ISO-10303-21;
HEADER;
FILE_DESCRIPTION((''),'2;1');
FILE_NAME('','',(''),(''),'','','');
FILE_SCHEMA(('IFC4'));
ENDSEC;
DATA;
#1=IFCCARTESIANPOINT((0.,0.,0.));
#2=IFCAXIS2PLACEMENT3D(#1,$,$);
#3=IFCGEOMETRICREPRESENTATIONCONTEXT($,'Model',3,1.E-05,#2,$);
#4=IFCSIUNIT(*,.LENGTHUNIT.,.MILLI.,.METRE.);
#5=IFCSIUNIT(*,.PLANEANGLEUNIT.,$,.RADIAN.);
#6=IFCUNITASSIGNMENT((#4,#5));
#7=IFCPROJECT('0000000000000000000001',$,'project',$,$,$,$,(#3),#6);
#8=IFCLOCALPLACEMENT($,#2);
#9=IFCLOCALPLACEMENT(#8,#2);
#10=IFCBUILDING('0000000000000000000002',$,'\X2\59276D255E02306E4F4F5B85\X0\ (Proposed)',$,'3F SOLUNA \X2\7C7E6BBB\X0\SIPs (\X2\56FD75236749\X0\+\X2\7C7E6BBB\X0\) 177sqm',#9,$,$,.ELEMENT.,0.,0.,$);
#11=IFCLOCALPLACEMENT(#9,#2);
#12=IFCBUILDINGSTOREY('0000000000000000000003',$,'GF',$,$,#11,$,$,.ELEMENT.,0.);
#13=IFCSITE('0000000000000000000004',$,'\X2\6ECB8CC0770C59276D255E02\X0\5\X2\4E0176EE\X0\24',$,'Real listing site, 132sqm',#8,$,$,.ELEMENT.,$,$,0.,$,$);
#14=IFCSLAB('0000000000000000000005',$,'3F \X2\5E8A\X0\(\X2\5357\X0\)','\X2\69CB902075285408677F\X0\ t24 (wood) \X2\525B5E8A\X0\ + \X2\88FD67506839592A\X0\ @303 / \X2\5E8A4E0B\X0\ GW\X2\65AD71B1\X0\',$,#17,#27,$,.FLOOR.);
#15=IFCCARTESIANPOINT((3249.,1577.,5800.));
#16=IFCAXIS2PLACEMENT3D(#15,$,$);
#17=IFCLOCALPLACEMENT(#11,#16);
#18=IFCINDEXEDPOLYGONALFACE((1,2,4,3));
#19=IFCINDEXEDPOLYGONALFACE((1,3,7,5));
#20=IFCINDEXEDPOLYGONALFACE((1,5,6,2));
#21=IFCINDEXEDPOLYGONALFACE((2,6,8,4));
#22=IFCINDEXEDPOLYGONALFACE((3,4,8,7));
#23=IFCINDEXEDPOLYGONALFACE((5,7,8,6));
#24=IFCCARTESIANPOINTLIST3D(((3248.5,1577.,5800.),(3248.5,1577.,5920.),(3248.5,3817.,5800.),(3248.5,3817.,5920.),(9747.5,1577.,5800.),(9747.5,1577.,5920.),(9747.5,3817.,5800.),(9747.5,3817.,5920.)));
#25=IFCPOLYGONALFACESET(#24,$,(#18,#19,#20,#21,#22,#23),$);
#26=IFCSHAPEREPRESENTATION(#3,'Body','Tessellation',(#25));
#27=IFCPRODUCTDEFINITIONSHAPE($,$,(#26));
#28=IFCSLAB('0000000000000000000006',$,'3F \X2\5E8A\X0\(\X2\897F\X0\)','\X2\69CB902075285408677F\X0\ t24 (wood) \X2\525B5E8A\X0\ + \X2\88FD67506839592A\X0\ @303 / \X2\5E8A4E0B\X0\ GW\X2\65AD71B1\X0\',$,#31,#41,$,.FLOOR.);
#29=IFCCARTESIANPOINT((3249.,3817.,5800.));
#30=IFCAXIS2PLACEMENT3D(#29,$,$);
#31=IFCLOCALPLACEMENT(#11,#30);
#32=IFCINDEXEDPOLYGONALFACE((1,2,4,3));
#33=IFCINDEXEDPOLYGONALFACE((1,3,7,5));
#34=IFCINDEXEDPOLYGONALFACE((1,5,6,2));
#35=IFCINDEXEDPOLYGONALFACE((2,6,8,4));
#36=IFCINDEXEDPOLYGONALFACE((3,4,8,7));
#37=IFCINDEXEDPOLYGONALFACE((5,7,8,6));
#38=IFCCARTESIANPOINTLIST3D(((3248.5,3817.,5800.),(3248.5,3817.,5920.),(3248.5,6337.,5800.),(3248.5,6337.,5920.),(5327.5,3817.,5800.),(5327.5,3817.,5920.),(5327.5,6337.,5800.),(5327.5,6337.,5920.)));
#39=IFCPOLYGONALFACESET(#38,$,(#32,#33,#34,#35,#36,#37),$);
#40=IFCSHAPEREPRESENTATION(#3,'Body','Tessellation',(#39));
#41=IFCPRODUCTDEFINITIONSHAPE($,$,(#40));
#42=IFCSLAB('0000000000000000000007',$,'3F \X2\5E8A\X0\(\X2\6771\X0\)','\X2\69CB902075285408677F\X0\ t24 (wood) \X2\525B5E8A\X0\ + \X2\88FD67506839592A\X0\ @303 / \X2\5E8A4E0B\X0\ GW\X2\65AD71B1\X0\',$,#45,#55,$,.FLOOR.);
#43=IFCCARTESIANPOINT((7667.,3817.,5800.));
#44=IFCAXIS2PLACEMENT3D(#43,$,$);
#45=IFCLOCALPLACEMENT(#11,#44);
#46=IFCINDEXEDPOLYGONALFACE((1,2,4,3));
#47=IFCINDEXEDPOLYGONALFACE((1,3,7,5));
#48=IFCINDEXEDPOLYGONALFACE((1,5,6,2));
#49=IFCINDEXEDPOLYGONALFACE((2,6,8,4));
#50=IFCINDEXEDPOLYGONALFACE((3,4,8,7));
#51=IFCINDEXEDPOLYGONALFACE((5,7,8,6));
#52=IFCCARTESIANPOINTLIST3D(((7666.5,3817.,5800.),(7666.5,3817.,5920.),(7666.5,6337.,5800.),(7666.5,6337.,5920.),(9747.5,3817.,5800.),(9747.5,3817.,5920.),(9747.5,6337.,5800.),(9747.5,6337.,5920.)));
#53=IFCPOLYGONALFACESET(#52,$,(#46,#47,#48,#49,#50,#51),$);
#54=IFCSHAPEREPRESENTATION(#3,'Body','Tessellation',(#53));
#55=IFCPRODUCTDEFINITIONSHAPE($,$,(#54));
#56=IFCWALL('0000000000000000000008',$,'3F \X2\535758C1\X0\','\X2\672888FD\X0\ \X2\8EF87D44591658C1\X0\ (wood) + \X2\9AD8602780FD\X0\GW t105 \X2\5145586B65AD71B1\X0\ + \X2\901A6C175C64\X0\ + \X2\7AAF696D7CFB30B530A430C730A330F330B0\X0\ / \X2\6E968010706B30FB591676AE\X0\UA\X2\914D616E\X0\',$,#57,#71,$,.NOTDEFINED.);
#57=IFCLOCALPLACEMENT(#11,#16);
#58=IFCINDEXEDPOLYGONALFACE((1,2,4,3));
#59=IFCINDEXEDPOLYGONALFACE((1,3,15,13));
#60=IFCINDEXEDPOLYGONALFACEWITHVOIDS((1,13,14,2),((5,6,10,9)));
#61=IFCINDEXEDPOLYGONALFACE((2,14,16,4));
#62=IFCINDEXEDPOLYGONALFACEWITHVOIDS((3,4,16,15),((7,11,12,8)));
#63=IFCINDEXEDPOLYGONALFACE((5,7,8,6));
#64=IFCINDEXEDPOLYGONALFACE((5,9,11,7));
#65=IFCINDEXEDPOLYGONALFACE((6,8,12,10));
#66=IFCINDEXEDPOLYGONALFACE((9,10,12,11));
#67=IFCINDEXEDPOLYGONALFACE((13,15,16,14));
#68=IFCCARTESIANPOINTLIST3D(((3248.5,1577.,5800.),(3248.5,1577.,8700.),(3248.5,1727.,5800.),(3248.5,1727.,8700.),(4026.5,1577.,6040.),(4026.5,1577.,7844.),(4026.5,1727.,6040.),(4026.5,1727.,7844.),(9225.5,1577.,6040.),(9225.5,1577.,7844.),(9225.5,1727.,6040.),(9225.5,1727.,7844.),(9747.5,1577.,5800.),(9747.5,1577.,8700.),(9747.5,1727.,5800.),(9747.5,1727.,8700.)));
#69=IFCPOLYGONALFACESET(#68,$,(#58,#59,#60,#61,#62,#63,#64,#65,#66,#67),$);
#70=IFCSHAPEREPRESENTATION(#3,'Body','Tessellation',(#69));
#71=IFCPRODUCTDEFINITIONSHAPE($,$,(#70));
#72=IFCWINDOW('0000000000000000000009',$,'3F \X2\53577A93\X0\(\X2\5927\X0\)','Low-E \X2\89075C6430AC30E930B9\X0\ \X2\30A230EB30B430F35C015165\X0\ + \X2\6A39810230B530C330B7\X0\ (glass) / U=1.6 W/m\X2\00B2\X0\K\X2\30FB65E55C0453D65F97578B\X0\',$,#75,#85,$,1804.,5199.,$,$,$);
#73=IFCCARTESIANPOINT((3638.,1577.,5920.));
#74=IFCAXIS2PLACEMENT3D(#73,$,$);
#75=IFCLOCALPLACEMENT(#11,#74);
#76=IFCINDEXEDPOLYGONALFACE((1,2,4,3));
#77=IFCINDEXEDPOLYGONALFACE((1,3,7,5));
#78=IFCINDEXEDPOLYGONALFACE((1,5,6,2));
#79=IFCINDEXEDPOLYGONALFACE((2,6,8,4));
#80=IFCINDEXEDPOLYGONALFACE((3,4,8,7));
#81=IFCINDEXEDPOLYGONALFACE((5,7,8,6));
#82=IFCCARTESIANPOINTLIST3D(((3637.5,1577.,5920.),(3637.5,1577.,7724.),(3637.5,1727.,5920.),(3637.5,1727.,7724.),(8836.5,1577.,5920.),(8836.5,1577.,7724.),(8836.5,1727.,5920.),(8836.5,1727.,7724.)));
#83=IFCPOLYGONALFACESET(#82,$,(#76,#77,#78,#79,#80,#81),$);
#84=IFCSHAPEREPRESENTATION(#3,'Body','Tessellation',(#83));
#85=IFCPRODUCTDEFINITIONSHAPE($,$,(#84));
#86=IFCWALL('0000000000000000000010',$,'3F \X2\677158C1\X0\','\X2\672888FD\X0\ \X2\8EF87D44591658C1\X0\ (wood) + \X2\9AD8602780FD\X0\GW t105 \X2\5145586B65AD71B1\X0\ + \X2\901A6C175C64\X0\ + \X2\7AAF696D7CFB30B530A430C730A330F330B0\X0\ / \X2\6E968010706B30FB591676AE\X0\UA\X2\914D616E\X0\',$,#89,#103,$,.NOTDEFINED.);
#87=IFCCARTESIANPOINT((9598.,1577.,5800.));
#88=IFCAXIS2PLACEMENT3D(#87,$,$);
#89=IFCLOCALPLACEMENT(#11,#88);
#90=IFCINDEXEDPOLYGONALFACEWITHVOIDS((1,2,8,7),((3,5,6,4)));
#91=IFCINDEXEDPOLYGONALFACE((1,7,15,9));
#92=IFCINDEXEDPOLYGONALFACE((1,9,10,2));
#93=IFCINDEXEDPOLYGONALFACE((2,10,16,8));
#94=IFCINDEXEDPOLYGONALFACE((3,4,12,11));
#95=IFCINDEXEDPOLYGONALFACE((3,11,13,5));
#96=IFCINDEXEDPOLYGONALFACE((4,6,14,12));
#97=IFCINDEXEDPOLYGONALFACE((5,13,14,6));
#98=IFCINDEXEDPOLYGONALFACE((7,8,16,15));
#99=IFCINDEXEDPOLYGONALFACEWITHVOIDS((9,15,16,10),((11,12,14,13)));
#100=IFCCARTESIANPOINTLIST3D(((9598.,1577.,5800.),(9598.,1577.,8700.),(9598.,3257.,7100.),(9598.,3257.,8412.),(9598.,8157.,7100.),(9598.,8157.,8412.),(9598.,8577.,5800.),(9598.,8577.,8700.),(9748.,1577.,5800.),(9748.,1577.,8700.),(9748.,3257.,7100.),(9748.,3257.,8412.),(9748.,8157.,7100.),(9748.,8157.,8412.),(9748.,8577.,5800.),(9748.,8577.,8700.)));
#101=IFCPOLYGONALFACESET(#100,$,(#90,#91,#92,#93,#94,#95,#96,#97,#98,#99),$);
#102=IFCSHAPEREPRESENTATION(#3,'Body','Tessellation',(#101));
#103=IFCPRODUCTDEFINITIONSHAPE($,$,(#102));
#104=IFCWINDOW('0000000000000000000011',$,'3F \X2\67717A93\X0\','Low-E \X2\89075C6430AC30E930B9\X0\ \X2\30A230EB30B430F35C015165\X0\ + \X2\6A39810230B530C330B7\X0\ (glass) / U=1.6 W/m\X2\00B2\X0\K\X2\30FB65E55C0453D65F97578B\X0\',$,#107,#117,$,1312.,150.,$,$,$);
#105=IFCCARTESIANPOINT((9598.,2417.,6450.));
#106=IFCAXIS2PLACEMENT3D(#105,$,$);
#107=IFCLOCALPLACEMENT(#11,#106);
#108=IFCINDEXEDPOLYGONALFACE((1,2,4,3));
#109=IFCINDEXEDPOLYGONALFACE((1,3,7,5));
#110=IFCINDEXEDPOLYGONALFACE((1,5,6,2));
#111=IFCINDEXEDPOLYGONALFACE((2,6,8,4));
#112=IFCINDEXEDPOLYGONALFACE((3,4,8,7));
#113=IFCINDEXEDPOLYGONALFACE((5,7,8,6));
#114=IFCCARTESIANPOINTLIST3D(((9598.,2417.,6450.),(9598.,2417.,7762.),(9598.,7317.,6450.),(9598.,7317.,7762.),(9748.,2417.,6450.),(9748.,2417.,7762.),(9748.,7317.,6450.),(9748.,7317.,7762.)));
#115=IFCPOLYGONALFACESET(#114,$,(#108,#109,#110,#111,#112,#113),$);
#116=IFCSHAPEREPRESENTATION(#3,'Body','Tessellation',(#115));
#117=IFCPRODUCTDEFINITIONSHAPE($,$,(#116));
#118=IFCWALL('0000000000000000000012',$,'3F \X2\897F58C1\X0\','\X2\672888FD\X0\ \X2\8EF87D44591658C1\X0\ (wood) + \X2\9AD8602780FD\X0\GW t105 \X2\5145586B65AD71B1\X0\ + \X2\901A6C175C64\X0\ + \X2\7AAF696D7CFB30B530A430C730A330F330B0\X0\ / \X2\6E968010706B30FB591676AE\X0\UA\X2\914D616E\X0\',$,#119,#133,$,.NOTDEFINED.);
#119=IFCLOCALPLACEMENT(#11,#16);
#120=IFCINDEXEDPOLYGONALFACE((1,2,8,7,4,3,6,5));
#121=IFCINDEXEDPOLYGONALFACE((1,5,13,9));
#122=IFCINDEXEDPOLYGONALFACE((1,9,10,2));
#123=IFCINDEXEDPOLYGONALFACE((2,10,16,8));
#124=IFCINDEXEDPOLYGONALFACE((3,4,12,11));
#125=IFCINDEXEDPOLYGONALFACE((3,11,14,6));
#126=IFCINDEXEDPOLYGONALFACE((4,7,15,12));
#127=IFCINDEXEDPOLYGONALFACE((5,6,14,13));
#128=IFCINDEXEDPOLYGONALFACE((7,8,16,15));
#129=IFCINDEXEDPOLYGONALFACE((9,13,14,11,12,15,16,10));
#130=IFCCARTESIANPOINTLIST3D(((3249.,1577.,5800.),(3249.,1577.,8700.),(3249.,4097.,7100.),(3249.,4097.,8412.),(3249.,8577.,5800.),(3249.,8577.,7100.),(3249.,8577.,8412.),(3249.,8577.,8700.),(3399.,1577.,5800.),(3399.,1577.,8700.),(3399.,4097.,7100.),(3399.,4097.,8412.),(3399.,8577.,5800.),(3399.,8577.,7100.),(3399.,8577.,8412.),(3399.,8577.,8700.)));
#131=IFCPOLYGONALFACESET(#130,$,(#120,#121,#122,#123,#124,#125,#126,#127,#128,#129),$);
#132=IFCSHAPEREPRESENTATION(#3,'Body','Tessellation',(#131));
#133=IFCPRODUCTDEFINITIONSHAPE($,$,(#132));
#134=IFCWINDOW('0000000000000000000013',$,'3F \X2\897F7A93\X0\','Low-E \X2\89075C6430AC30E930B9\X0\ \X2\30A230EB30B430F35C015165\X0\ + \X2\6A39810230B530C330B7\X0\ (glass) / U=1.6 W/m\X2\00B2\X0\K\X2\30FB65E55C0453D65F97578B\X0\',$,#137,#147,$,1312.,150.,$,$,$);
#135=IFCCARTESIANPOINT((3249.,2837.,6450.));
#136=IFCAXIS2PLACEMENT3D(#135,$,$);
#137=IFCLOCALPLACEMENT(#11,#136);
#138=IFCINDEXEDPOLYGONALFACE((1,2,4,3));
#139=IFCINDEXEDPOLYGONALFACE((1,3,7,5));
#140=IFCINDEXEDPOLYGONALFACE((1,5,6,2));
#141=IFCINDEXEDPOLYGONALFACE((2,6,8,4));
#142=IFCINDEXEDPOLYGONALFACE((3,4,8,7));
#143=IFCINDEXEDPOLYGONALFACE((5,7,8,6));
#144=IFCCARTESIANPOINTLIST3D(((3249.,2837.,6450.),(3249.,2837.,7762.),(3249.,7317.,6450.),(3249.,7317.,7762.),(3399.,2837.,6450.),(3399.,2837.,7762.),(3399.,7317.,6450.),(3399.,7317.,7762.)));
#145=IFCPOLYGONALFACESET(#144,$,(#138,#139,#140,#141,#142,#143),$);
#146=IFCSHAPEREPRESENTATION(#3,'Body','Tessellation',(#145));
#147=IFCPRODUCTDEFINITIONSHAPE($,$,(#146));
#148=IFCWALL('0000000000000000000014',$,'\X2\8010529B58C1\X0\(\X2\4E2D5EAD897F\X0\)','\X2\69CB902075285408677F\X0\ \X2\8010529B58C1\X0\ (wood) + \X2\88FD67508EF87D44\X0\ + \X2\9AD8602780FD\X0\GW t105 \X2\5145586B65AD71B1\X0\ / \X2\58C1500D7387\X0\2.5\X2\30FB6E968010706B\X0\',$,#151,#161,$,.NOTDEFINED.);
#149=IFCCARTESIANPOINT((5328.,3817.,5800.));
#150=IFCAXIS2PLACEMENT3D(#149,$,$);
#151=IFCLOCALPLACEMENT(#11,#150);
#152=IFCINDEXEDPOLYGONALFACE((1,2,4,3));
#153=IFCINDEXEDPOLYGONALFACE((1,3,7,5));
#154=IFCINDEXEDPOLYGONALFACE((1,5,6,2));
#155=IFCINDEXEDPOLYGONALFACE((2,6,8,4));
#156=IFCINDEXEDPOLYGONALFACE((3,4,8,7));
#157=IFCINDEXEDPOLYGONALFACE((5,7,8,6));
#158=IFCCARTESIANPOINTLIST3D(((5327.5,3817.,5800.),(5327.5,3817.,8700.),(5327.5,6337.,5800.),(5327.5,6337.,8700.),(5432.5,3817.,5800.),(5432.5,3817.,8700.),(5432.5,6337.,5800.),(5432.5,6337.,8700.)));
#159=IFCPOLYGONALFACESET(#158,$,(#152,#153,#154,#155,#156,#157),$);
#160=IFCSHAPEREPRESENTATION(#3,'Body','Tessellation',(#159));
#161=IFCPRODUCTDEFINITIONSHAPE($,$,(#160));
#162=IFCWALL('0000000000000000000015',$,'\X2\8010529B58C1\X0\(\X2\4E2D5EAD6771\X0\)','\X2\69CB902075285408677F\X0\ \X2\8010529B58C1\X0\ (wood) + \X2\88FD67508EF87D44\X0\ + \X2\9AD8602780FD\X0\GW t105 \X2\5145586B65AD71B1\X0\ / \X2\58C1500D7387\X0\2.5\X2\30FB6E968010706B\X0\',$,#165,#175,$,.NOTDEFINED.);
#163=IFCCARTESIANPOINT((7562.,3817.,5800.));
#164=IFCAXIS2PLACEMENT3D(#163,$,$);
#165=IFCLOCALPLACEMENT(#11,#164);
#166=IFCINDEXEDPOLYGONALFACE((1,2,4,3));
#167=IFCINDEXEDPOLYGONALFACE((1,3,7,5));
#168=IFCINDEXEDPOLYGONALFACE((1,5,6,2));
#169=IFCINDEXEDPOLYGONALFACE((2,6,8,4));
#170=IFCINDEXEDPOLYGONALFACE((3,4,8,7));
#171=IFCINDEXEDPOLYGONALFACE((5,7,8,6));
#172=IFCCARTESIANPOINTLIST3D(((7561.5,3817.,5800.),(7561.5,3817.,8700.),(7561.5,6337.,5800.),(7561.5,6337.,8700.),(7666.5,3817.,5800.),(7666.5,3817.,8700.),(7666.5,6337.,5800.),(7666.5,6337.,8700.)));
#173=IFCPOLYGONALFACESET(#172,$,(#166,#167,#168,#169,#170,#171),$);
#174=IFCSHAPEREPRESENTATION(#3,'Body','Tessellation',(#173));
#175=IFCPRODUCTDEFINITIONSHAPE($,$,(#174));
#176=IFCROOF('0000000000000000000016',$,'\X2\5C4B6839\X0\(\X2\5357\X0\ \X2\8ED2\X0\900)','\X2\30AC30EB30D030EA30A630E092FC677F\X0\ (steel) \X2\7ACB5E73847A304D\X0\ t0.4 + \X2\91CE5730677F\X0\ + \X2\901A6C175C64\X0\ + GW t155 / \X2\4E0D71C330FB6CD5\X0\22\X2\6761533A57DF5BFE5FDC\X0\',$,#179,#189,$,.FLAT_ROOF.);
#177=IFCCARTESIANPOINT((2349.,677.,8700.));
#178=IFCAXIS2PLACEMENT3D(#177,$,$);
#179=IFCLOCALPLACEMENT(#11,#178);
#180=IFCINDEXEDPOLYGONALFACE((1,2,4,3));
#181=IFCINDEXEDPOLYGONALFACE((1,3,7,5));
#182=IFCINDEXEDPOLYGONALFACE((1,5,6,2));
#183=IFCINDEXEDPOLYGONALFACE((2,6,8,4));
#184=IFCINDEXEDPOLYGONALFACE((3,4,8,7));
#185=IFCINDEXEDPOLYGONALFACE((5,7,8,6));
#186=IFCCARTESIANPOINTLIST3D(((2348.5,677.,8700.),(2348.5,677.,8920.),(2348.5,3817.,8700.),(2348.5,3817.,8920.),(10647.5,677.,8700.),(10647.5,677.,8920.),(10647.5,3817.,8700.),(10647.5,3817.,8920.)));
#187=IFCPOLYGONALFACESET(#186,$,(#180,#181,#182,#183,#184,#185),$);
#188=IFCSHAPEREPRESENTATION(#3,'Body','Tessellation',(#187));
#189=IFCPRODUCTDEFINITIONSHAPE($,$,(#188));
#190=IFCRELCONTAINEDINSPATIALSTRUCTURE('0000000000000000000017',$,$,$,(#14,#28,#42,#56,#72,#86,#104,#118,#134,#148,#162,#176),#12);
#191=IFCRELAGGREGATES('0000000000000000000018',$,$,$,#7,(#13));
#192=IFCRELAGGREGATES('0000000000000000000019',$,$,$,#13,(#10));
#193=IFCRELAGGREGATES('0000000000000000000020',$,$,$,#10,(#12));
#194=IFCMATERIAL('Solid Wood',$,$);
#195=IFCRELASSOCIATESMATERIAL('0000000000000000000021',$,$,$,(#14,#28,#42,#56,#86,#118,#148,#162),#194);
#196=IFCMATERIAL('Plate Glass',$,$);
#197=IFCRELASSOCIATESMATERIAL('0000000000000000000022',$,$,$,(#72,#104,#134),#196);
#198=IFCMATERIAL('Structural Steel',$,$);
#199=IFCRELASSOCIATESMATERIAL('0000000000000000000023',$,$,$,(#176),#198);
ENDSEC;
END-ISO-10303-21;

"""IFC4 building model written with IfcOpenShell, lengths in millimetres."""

from ifc_helpers import new_model, si_unit, frame, frame_2d, origin, place, context, project, spatial, rectangle, extrude, material, element, fill, save


model = new_model("IFC4")

# Units and contexts
model_context = context("Model", 3, precision=1e-05, world=origin())
ifc_project = project(units=[si_unit("LENGTHUNIT", "METRE", prefix="MILLI"), si_unit("PLANEANGLEUNIT", "RADIAN")], contexts=[model_context])

# Site, building, storey
site_placement = place(None, origin())
site = spatial("IfcSite", under=ifc_project, at=site_placement, Name="滋賀県大津市5丁目24", ObjectType="Real listing site, 132sqm", CompositionType="ELEMENT", RefElevation=0.0)
building_placement = place(site_placement, origin())
building = spatial("IfcBuilding", under=site, at=building_placement, Name="大津市の住宅 (Proposed)", ObjectType="3F SOLUNA 籾殻SIPs (国産杉+籾殻) 177sqm", CompositionType="ELEMENT", ElevationOfRefHeight=0.0, ElevationOfTerrain=0.0)
storey_placement = place(building_placement, origin())
storey = spatial("IfcBuildingStorey", under=building, at=storey_placement, Name="GF", CompositionType="ELEMENT", Elevation=0.0)

# Slabs
ifc_material_1 = material(Name="Solid Wood")
slab_1_placement = place(storey_placement, frame((3249.0, 1577.0, 5800.0)))
element("IfcSlab", 1, at=slab_1_placement, inside=storey, material=ifc_material_1, Name="3F 床(南)", Description="構造用合板 t24 (wood) 剛床 + 製材根太 @303 / 床下 GW断熱", PredefinedType="FLOOR", context=model_context, shape_type="SweptSolid", body=[
    extrude(rectangle(XDim=6499.0, YDim=2240.0, at=frame_2d((3249.0, 1120.0))), frame((3249.0, 1577.0, 5800.0)), (0.0, 0.0, 1.0), 120.0),
])
slab_2_placement = place(storey_placement, frame((3249.0, 3817.0, 5800.0)))
element("IfcSlab", 2, at=slab_2_placement, inside=storey, material=ifc_material_1, Name="3F 床(西)", Description="構造用合板 t24 (wood) 剛床 + 製材根太 @303 / 床下 GW断熱", PredefinedType="FLOOR", context=model_context, shape_type="SweptSolid", body=[
    extrude(rectangle(XDim=2079.0, YDim=2520.0, at=frame_2d((1039.0, 1260.0))), frame((3249.0, 3817.0, 5800.0)), (0.0, 0.0, 1.0), 120.0),
])
slab_3_placement = place(storey_placement, frame((7667.0, 3817.0, 5800.0)))
element("IfcSlab", 3, at=slab_3_placement, inside=storey, material=ifc_material_1, Name="3F 床(東)", Description="構造用合板 t24 (wood) 剛床 + 製材根太 @303 / 床下 GW断熱", PredefinedType="FLOOR", context=model_context, shape_type="SweptSolid", body=[
    extrude(rectangle(XDim=2081.0, YDim=2520.0, at=frame_2d((1040.0, 1260.0))), frame((7667.0, 3817.0, 5800.0)), (0.0, 0.0, 1.0), 120.0),
])

# Walls, openings, windows
wall_1_placement = place(storey_placement, frame((3249.0, 1577.0, 5800.0)))
wall_1 = element("IfcWall", 4, at=wall_1_placement, inside=storey, material=ifc_material_1, Name="3F 南壁", Description="木製 軸組外壁 (wood) + 高性能GW t105 充填断熱 + 通気層 + 窯業系サイディング / 準耐火・外皮UA配慮", PredefinedType="NOTDEFINED", context=model_context, shape_type="SweptSolid", body=[
    extrude(rectangle(XDim=6499.0, YDim=150.0, at=frame_2d((3249.0, 75.0))), frame((3249.0, 1577.0, 5800.0)), (0.0, 0.0, 1.0), 2900.0),
])
opening_1_placement = place(storey_placement, frame((3638.0, 1577.0, 5920.0)))
opening_1 = element("IfcOpeningElement", 5, at=opening_1_placement, cuts=wall_1, PredefinedType="NOTDEFINED", context=model_context, shape_type="SweptSolid", body=[
    extrude(rectangle(XDim=5199.0, YDim=150.0, at=frame_2d((2599.0, 75.0))), frame((3638.0, 1577.0, 5920.0)), (0.0, 0.0, 1.0), 1804.0),
])
ifc_material_2 = material(Name="Plate Glass")
window_1_placement = place(storey_placement, frame((3638.0, 1577.0, 5920.0)))
window_1 = element("IfcWindow", 6, at=window_1_placement, inside=storey, material=ifc_material_2, Name="3F 南窓(大)", Description="Low-E 複層ガラス アルゴン封入 + 樹脂サッシ (glass) / U=1.6 W/m²K・日射取得型", OverallHeight=1804.0, OverallWidth=5199.0, context=model_context, shape_type="SweptSolid", body=[
    extrude(rectangle(XDim=5199.0, YDim=150.0, at=frame_2d((2599.0, 75.0))), frame((3638.0, 1577.0, 5920.0)), (0.0, 0.0, 1.0), 1804.0),
])
fill(opening_1, window_1)
wall_2_placement = place(storey_placement, frame((9598.0, 1577.0, 5800.0)))
wall_2 = element("IfcWall", 7, at=wall_2_placement, inside=storey, material=ifc_material_1, Name="3F 東壁", Description="木製 軸組外壁 (wood) + 高性能GW t105 充填断熱 + 通気層 + 窯業系サイディング / 準耐火・外皮UA配慮", PredefinedType="NOTDEFINED", context=model_context, shape_type="SweptSolid", body=[
    extrude(rectangle(XDim=150.0, YDim=7000.0, at=frame_2d((75.0, 3500.0))), frame((9598.0, 1577.0, 5800.0)), (0.0, 0.0, 1.0), 2900.0),
])
opening_2_placement = place(storey_placement, frame((9598.0, 2417.0, 6450.0)))
opening_2 = element("IfcOpeningElement", 8, at=opening_2_placement, cuts=wall_2, PredefinedType="NOTDEFINED", context=model_context, shape_type="SweptSolid", body=[
    extrude(rectangle(XDim=150.0, YDim=4900.0, at=frame_2d((75.0, 2450.0))), frame((9598.0, 2417.0, 6450.0)), (0.0, 0.0, 1.0), 1312.0),
])
window_2_placement = place(storey_placement, frame((9598.0, 2417.0, 6450.0)))
window_2 = element("IfcWindow", 9, at=window_2_placement, inside=storey, material=ifc_material_2, Name="3F 東窓", Description="Low-E 複層ガラス アルゴン封入 + 樹脂サッシ (glass) / U=1.6 W/m²K・日射取得型", OverallHeight=1312.0, OverallWidth=150.0, context=model_context, shape_type="SweptSolid", body=[
    extrude(rectangle(XDim=150.0, YDim=4900.0, at=frame_2d((75.0, 2450.0))), frame((9598.0, 2417.0, 6450.0)), (0.0, 0.0, 1.0), 1312.0),
])
fill(opening_2, window_2)
wall_3_placement = place(storey_placement, frame((3249.0, 1577.0, 5800.0)))
wall_3 = element("IfcWall", 10, at=wall_3_placement, inside=storey, material=ifc_material_1, Name="3F 西壁", Description="木製 軸組外壁 (wood) + 高性能GW t105 充填断熱 + 通気層 + 窯業系サイディング / 準耐火・外皮UA配慮", PredefinedType="NOTDEFINED", context=model_context, shape_type="SweptSolid", body=[
    extrude(rectangle(XDim=150.0, YDim=7000.0, at=frame_2d((75.0, 3500.0))), frame((3249.0, 1577.0, 5800.0)), (0.0, 0.0, 1.0), 2900.0),
])
opening_3_placement = place(storey_placement, frame((3249.0, 2837.0, 6450.0)))
opening_3 = element("IfcOpeningElement", 11, at=opening_3_placement, cuts=wall_3, PredefinedType="NOTDEFINED", context=model_context, shape_type="SweptSolid", body=[
    extrude(rectangle(XDim=150.0, YDim=4480.0, at=frame_2d((75.0, 2240.0))), frame((3249.0, 2837.0, 6450.0)), (0.0, 0.0, 1.0), 1312.0),
])
window_3_placement = place(storey_placement, frame((3249.0, 2837.0, 6450.0)))
window_3 = element("IfcWindow", 12, at=window_3_placement, inside=storey, material=ifc_material_2, Name="3F 西窓", Description="Low-E 複層ガラス アルゴン封入 + 樹脂サッシ (glass) / U=1.6 W/m²K・日射取得型", OverallHeight=1312.0, OverallWidth=150.0, context=model_context, shape_type="SweptSolid", body=[
    extrude(rectangle(XDim=150.0, YDim=4480.0, at=frame_2d((75.0, 2240.0))), frame((3249.0, 2837.0, 6450.0)), (0.0, 0.0, 1.0), 1312.0),
])
fill(opening_3, window_3)

# Walls
wall_4_placement = place(storey_placement, frame((5328.0, 3817.0, 5800.0)))
element("IfcWall", 13, at=wall_4_placement, inside=storey, material=ifc_material_1, Name="耐力壁(中庭西)", Description="構造用合板 耐力壁 (wood) + 製材軸組 + 高性能GW t105 充填断熱 / 壁倍率2.5・準耐火", PredefinedType="NOTDEFINED", context=model_context, shape_type="SweptSolid", body=[
    extrude(rectangle(XDim=105.0, YDim=2520.0, at=frame_2d((52.0, 1260.0))), frame((5328.0, 3817.0, 5800.0)), (0.0, 0.0, 1.0), 2900.0),
])
wall_5_placement = place(storey_placement, frame((7562.0, 3817.0, 5800.0)))
element("IfcWall", 14, at=wall_5_placement, inside=storey, material=ifc_material_1, Name="耐力壁(中庭東)", Description="構造用合板 耐力壁 (wood) + 製材軸組 + 高性能GW t105 充填断熱 / 壁倍率2.5・準耐火", PredefinedType="NOTDEFINED", context=model_context, shape_type="SweptSolid", body=[
    extrude(rectangle(XDim=105.0, YDim=2520.0, at=frame_2d((52.0, 1260.0))), frame((7562.0, 3817.0, 5800.0)), (0.0, 0.0, 1.0), 2900.0),
])

# Roof
ifc_material_3 = material(Name="Structural Steel")
roof_1_placement = place(storey_placement, frame((2349.0, 677.0, 8700.0)))
element("IfcRoof", 15, at=roof_1_placement, inside=storey, material=ifc_material_3, Name="屋根(南 軒900)", Description="ガルバリウム鋼板 (steel) 立平葺き t0.4 + 野地板 + 通気層 + GW t155 / 不燃・法22条区域対応", PredefinedType="FLAT_ROOF", context=model_context, shape_type="SweptSolid", body=[
    extrude(rectangle(XDim=8299.0, YDim=3140.0, at=frame_2d((4149.0, 1570.0))), frame((2349.0, 677.0, 8700.0)), (0.0, 0.0, 1.0), 220.0),
])

save(model, "model.ifc")
